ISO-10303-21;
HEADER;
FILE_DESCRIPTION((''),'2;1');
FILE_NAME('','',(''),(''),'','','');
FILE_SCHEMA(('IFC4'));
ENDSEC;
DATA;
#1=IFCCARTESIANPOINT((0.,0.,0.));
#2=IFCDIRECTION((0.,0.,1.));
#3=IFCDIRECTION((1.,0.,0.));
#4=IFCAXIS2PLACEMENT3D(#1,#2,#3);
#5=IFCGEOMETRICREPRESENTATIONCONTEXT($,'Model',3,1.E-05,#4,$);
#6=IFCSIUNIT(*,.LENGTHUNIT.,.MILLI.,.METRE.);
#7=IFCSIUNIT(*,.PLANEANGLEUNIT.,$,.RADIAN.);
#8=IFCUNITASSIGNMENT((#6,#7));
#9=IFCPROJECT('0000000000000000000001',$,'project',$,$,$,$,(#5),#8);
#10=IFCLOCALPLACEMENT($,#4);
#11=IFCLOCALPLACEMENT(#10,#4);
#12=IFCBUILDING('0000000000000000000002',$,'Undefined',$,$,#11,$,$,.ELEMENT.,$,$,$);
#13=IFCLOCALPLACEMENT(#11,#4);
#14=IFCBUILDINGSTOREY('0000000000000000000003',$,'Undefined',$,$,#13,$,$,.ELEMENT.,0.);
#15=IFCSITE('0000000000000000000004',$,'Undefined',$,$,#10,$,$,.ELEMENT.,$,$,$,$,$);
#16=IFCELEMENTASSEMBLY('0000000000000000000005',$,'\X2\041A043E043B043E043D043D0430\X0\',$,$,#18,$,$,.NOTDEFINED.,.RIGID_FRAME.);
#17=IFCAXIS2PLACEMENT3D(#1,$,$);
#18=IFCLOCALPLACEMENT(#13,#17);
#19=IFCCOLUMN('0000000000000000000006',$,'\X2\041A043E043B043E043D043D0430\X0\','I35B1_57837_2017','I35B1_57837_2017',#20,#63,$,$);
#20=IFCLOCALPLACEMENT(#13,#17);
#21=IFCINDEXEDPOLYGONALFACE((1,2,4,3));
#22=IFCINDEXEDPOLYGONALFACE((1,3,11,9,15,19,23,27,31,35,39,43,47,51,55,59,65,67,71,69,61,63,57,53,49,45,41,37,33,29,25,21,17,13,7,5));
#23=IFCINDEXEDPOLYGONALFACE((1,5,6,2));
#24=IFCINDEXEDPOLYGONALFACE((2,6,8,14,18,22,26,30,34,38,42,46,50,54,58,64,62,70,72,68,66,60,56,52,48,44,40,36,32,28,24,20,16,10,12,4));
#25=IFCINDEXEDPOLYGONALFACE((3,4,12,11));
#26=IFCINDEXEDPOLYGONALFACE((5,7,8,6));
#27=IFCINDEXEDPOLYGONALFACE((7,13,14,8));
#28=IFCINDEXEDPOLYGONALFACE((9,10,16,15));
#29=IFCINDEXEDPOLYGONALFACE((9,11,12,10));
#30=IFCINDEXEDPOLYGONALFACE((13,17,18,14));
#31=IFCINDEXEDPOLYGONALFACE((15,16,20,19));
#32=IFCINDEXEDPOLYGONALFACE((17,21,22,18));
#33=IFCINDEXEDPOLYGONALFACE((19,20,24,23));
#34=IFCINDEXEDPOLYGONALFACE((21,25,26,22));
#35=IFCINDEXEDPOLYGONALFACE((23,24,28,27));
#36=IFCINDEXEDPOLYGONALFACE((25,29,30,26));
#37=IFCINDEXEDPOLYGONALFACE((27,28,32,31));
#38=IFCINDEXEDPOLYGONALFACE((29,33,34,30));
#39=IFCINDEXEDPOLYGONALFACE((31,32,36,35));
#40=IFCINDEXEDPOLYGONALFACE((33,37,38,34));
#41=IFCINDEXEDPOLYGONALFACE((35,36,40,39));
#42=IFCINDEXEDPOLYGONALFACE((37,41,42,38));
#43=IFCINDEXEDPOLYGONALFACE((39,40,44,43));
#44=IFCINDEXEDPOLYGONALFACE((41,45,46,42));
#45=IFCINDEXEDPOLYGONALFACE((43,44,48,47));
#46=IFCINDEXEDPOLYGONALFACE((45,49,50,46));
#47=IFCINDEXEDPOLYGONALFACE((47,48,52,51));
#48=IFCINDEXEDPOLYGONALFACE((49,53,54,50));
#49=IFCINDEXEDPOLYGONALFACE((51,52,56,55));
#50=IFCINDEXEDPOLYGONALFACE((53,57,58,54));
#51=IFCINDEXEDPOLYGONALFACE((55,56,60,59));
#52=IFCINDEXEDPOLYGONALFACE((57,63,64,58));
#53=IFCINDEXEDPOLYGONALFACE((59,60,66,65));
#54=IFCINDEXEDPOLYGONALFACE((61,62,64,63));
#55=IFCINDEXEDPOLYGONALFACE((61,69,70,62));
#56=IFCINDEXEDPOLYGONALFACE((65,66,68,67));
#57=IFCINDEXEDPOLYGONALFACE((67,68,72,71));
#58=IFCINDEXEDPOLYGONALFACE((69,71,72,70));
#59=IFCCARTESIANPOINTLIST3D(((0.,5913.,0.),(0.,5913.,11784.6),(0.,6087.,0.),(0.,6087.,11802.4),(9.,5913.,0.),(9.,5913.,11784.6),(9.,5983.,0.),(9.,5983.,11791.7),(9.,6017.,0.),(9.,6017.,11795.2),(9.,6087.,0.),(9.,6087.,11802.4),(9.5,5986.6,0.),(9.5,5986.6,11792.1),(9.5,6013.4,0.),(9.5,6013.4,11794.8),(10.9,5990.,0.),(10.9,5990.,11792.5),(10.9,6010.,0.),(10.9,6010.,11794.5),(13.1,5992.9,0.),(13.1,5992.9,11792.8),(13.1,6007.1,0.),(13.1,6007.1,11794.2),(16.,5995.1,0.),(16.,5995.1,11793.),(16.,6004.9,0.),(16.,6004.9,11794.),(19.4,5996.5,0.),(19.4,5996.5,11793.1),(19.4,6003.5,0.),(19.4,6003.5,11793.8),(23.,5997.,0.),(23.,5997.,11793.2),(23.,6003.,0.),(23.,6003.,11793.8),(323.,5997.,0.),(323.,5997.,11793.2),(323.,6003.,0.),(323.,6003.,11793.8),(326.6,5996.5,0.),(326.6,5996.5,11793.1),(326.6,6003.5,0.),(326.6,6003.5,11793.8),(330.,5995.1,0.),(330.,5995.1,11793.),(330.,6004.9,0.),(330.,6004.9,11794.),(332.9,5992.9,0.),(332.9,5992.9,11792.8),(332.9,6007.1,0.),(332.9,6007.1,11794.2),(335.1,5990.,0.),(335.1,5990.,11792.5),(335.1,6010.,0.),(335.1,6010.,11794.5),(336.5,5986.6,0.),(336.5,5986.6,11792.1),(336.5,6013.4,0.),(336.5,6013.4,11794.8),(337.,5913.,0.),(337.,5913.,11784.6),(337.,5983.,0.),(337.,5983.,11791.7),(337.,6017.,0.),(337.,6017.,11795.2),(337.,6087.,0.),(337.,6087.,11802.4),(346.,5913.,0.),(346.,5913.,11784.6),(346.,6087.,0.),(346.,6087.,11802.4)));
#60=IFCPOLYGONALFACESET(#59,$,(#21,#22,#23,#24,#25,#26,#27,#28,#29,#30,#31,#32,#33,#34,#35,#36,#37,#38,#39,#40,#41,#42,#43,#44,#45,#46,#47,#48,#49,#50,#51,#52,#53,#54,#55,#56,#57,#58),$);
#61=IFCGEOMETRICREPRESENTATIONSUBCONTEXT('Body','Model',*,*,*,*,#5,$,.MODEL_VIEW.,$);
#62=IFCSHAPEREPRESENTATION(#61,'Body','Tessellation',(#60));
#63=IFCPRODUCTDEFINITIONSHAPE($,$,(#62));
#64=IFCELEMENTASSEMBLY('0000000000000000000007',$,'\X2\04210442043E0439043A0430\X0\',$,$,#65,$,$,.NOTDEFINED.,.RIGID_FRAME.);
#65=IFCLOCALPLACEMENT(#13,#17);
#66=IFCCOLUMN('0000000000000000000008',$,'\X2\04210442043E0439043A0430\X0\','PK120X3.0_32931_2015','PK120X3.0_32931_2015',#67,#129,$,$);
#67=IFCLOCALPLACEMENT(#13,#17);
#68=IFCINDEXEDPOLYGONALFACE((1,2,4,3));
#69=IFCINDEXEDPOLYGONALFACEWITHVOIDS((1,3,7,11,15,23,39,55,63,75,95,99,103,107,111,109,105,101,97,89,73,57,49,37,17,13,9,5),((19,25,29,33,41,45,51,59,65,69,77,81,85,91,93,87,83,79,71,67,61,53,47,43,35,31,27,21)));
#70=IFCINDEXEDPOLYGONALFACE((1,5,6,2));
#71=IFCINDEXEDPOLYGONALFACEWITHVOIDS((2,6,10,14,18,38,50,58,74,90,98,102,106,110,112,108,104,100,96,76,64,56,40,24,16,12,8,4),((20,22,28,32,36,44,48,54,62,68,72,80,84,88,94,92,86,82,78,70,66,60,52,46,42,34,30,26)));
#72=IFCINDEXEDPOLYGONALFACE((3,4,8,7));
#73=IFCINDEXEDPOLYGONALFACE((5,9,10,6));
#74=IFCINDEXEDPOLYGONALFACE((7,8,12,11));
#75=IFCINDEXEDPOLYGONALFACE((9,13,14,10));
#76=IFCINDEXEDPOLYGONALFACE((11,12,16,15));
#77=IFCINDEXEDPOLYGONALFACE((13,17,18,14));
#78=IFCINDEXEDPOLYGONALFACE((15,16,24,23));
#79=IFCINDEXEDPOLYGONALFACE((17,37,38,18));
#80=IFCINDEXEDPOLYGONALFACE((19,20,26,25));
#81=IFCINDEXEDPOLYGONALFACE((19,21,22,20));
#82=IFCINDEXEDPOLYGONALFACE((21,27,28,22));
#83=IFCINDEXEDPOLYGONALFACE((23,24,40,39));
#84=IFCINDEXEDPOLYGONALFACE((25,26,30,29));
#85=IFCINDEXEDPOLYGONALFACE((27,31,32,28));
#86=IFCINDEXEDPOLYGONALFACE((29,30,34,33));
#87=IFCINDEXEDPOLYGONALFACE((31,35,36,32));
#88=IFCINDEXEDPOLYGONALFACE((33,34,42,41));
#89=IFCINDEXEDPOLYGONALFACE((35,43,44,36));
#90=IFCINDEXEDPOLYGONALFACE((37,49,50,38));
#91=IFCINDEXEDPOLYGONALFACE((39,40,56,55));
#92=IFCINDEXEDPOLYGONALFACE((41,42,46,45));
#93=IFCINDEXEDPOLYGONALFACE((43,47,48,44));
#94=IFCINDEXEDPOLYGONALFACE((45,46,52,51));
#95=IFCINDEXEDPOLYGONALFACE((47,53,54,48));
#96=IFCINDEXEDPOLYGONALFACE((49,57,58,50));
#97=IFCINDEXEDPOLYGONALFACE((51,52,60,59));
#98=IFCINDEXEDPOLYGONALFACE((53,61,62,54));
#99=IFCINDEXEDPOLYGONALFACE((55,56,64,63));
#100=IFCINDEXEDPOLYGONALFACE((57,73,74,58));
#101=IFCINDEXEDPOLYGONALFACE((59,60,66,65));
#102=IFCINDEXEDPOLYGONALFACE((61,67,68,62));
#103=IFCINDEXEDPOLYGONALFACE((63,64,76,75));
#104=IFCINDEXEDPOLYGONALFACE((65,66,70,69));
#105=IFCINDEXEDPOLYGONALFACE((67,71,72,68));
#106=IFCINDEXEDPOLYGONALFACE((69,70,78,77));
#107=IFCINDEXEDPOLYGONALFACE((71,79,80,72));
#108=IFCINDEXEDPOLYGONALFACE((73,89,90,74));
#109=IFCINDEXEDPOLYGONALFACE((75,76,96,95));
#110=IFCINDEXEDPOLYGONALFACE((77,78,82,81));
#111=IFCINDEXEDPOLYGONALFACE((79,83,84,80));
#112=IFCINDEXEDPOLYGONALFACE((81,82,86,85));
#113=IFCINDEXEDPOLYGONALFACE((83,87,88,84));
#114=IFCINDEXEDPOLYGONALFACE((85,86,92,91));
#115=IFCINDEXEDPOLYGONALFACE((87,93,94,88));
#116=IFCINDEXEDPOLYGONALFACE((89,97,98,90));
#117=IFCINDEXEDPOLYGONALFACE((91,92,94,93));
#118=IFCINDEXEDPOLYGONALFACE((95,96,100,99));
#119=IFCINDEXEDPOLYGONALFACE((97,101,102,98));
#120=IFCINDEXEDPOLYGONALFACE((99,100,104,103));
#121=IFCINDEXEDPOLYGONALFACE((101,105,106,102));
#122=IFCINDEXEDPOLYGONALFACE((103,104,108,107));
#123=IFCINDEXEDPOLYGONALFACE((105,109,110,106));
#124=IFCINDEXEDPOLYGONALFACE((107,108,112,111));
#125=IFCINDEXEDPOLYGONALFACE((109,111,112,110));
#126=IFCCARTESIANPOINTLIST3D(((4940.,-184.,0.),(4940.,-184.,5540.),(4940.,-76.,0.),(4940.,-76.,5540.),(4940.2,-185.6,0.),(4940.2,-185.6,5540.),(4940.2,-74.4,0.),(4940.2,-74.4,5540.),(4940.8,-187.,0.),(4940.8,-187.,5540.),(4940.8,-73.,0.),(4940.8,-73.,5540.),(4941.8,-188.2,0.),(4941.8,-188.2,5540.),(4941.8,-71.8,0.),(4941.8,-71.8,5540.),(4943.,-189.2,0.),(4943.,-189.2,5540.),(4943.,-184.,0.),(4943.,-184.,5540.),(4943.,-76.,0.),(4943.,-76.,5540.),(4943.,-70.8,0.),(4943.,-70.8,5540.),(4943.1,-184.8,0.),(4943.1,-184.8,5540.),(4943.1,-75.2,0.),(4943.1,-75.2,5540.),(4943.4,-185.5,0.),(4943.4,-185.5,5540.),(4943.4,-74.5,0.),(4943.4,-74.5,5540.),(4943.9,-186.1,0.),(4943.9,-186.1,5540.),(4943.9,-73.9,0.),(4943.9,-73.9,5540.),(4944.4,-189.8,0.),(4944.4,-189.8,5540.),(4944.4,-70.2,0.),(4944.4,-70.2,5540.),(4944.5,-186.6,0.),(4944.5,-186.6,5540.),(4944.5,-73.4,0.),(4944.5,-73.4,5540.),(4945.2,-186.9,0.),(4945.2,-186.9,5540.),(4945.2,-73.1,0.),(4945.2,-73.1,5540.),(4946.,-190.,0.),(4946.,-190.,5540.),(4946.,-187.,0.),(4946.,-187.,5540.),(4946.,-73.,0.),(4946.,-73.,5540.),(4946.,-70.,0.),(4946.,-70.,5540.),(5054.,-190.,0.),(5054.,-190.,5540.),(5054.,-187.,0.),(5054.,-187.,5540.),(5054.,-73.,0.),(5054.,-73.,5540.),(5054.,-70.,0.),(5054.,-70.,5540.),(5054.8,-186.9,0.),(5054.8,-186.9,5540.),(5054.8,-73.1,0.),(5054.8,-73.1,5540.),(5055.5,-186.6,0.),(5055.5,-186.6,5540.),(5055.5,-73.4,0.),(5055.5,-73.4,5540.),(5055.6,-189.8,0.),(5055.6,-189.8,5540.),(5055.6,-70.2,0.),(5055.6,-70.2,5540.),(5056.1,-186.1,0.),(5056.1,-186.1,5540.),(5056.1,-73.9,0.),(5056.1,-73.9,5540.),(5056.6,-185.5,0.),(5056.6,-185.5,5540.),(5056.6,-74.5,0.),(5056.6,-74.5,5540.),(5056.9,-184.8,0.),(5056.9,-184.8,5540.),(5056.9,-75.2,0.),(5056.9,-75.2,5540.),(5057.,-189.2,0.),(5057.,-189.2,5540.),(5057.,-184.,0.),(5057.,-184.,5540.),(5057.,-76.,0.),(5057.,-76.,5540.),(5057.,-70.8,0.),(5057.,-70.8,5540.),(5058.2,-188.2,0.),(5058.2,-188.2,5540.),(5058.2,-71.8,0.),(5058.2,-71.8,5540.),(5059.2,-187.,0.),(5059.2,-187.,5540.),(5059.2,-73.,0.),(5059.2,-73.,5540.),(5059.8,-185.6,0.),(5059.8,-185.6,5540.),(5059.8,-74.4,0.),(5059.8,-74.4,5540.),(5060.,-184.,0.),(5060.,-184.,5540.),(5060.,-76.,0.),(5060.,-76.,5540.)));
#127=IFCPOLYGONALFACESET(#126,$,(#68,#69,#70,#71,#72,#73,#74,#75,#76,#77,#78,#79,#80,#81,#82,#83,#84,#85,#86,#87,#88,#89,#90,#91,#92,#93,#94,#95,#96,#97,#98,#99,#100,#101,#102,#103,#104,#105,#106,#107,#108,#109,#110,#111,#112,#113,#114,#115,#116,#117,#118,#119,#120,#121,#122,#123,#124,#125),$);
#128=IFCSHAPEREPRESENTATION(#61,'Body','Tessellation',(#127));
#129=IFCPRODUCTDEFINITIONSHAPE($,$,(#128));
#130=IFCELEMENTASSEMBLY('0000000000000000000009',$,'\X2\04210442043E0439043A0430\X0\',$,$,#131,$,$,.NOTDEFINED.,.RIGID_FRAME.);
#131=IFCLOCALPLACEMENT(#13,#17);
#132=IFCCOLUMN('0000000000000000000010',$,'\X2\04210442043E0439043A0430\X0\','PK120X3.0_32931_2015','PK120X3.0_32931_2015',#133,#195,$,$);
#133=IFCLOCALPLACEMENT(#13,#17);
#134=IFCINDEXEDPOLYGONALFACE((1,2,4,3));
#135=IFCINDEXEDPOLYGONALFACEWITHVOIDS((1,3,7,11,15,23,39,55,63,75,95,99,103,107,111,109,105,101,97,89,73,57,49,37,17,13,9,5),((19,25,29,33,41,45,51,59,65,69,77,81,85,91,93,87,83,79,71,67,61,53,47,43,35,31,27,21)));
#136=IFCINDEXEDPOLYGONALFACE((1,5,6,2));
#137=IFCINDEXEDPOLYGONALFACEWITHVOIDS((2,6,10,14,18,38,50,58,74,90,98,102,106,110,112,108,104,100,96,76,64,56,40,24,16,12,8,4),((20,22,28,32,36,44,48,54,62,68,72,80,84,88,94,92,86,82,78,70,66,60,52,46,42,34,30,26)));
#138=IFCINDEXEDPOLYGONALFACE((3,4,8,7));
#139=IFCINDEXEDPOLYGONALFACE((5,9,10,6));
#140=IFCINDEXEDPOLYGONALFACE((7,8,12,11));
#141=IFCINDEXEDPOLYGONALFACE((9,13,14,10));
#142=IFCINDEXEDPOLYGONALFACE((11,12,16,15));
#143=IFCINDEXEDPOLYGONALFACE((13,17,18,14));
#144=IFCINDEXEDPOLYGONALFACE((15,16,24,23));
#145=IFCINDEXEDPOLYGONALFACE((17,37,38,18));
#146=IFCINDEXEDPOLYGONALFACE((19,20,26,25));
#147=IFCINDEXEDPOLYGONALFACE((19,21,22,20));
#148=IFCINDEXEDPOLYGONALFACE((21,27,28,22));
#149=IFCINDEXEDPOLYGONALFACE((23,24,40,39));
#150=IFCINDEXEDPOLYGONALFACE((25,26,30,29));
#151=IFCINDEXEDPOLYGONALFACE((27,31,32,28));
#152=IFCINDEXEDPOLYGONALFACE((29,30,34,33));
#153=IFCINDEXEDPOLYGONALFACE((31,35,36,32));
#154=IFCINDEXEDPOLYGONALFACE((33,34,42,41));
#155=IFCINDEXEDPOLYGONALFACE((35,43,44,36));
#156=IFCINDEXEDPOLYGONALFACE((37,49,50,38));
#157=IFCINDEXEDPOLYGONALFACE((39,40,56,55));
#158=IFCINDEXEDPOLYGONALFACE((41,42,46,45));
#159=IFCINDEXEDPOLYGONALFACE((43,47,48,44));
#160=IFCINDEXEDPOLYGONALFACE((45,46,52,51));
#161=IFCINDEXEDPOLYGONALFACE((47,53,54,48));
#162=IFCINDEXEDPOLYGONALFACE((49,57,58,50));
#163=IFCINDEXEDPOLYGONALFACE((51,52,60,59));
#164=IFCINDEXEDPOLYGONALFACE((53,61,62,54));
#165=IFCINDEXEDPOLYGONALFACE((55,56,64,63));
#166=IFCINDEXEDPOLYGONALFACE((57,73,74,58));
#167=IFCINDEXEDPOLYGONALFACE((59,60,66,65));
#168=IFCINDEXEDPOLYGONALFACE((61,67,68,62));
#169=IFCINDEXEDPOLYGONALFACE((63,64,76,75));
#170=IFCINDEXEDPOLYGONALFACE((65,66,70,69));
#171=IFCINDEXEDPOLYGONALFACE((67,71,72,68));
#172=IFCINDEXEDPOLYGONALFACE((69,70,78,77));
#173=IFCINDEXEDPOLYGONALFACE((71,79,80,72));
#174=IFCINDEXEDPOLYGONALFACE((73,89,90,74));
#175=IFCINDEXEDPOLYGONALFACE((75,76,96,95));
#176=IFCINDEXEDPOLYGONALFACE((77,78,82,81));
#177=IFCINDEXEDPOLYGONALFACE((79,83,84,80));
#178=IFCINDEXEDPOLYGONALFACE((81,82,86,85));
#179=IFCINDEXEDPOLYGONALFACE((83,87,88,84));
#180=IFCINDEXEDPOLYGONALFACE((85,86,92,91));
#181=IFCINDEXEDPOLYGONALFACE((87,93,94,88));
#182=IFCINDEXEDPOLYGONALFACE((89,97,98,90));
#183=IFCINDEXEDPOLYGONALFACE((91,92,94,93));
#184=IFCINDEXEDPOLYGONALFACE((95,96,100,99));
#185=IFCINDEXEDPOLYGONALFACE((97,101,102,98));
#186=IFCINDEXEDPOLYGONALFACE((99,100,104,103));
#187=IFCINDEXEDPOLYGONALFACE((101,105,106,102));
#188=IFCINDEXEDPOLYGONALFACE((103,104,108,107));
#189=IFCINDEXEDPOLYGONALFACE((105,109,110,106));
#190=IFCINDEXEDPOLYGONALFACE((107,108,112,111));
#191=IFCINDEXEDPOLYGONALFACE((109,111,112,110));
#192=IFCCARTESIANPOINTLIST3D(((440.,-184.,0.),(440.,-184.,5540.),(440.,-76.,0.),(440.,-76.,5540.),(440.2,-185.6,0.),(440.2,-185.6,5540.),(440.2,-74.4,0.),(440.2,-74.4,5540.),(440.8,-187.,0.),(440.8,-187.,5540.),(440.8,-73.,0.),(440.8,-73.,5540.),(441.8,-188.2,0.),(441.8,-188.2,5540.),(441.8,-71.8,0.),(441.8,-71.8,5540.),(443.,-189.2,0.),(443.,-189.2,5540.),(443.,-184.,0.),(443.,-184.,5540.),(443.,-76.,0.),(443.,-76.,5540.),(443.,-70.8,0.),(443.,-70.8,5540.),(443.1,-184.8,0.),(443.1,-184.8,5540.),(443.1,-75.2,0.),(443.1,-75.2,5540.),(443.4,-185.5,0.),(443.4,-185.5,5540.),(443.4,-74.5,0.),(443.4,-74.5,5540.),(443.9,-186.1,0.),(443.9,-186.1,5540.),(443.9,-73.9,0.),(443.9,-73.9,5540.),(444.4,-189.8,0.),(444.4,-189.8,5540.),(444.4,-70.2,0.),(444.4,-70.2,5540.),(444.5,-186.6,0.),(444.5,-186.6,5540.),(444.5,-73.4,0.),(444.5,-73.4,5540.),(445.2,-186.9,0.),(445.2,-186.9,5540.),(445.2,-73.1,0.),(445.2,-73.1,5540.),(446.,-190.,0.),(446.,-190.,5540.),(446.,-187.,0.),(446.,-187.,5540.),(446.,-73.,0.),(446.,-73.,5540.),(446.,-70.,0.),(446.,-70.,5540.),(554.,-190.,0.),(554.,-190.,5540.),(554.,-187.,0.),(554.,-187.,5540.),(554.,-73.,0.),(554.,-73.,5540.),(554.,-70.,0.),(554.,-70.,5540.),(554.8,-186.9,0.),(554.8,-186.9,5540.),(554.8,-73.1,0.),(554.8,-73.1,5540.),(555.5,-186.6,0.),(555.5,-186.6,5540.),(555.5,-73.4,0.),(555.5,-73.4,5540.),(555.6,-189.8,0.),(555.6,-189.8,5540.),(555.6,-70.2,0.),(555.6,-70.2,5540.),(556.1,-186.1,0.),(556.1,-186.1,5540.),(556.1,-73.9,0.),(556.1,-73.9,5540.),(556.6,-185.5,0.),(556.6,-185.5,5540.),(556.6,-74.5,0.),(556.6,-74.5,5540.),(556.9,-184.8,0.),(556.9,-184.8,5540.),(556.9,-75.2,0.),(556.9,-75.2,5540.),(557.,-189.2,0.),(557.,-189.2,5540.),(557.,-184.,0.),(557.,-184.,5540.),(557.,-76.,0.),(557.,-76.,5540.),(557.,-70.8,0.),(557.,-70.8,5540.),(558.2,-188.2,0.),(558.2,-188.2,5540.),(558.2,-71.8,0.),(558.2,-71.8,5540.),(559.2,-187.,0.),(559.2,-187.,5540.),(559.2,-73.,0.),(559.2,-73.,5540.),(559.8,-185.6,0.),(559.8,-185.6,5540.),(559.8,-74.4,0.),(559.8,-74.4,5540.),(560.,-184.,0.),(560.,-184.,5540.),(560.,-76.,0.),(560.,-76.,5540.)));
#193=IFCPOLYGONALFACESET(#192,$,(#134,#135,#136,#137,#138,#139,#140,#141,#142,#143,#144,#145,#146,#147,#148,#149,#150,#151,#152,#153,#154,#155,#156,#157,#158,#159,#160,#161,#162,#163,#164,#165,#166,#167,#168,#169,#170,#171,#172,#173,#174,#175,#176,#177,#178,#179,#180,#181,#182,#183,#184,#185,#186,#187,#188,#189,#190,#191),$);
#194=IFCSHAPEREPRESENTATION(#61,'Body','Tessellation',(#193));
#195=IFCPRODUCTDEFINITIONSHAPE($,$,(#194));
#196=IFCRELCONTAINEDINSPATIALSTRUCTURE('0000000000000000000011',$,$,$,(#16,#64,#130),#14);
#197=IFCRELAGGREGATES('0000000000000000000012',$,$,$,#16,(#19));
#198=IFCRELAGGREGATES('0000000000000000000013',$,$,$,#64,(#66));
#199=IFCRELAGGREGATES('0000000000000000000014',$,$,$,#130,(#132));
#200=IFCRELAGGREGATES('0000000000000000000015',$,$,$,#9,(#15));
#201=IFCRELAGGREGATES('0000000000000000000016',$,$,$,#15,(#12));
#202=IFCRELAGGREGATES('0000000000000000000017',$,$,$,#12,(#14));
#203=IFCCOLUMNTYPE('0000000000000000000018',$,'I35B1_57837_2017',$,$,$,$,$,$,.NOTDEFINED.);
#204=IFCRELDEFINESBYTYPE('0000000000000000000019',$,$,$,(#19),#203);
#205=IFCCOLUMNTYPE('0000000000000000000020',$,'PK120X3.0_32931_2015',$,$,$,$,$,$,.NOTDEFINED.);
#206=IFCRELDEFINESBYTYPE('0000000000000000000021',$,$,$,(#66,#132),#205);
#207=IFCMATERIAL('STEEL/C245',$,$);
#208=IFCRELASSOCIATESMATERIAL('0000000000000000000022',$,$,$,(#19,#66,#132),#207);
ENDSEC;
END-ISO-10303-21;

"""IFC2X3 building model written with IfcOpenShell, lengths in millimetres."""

from ifc_helpers import new_model, si_unit, frame, origin_with_axes, origin_2d_with_axis, place, context, subcontext, project, spatial, hollow_rectangle, i_section, extrude, clip, halfspace, material, type_object, element, aggregate, save


model = new_model("IFC2X3")

# Units and contexts
model_context = context("Model", 3, precision=1e-05, world=origin_with_axes())
body_context = subcontext(model_context, "Body", "Model", "MODEL_VIEW")
ifc_project = project(units=[si_unit("LENGTHUNIT", "METRE", prefix="MILLI"), si_unit("PLANEANGLEUNIT", "RADIAN")], contexts=[model_context])

# Site, building, storey
site_placement = place(None, origin_with_axes())
site = spatial("IfcSite", under=ifc_project, at=site_placement, Name="Undefined", CompositionType="ELEMENT")
building_placement = place(site_placement, origin_with_axes())
building = spatial("IfcBuilding", under=site, at=building_placement, Name="Undefined", CompositionType="ELEMENT")
storey_placement = place(building_placement, origin_with_axes())
storey = spatial("IfcBuildingStorey", under=building, at=storey_placement, Name="Undefined", CompositionType="ELEMENT", Elevation=0.0)

# Element assemblies, columns
assembly_1_placement = place(storey_placement, origin_with_axes())
assembly_1 = element("IfcElementAssembly", 1, at=assembly_1_placement, inside=storey, Name="Колонна", AssemblyPlace="NOTDEFINED", PredefinedType="RIGID_FRAME")
ifc_material_1 = material(Name="STEEL/C245")
column_type_1 = type_object("IfcColumnType", Name="I35B1_57837_2017", PredefinedType="NOTDEFINED")
column_1_placement = place(assembly_1_placement, frame((173.0, 6000.0, 0.0), z_axis=(0.0, 0.0, 1.0), x_axis=(-1.0, 0.0, 0.0)))
column_1 = element("IfcColumn", 2, at=column_1_placement, type_object=column_type_1, material=ifc_material_1, Name="Колонна", Description="I35B1_57837_2017", ObjectType="I35B1_57837_2017", context=body_context, shape_type="Clipping", body=[
    clip(extrude(i_section(OverallWidth=174.0, OverallDepth=346.0, WebThickness=6.0, FlangeThickness=9.0, FilletRadius=14.0, at=origin_2d_with_axis()), frame((0.0, 0.0, 11802.5), z_axis=(0.0, 0.0, -1.0), x_axis=(0.0, 1.0, 0.0)), (0.0, 0.0, 1.0), 11802.5), halfspace(frame((23.0, 208.8, 11772.1), z_axis=(0.0, -0.101645, -0.994821), x_axis=(-1.0, 0.0, 0.0)), True)),
])
aggregate(assembly_1, [column_1])
assembly_2_placement = place(storey_placement, origin_with_axes())
assembly_2 = element("IfcElementAssembly", 3, at=assembly_2_placement, inside=storey, Name="Стойка", AssemblyPlace="NOTDEFINED", PredefinedType="RIGID_FRAME")
column_type_2 = type_object("IfcColumnType", Name="PK120X3.0_32931_2015", PredefinedType="NOTDEFINED")
column_2_placement = place(assembly_2_placement, frame((5000.0, -130.0, 0.0), z_axis=(0.0, 0.0, 1.0), x_axis=(0.0, 1.0, 0.0)))
column_2 = element("IfcColumn", 4, at=column_2_placement, type_object=column_type_2, material=ifc_material_1, Name="Стойка", Description="PK120X3.0_32931_2015", ObjectType="PK120X3.0_32931_2015", context=body_context, shape_type="SweptSolid", body=[
    extrude(hollow_rectangle(XDim=120.0, YDim=120.0, WallThickness=3.0, InnerFilletRadius=3.0, OuterFilletRadius=6.0, at=origin_2d_with_axis()), frame((0.0, 0.0, 5540.0), z_axis=(0.0, 0.0, -1.0), x_axis=(0.0, 1.0, 0.0)), (0.0, 0.0, 1.0), 5540.0),
])
aggregate(assembly_2, [column_2])
assembly_3_placement = place(storey_placement, origin_with_axes())
assembly_3 = element("IfcElementAssembly", 5, at=assembly_3_placement, inside=storey, Name="Стойка", AssemblyPlace="NOTDEFINED", PredefinedType="RIGID_FRAME")
column_3_placement = place(assembly_3_placement, frame((500.0, -130.0, 0.0), z_axis=(0.0, 0.0, 1.0), x_axis=(0.0, 1.0, 0.0)))
column_3 = element("IfcColumn", 6, at=column_3_placement, type_object=column_type_2, material=ifc_material_1, Name="Стойка", Description="PK120X3.0_32931_2015", ObjectType="PK120X3.0_32931_2015", context=body_context, shape_type="SweptSolid", body=[
    extrude(hollow_rectangle(XDim=120.0, YDim=120.0, WallThickness=3.0, InnerFilletRadius=3.0, OuterFilletRadius=6.0, at=origin_2d_with_axis()), frame((0.0, 0.0, 5540.0), z_axis=(0.0, 0.0, -1.0), x_axis=(0.0, 1.0, 0.0)), (0.0, 0.0, 1.0), 5540.0),
])
aggregate(assembly_3, [column_3])

save(model, "model.ifc")
